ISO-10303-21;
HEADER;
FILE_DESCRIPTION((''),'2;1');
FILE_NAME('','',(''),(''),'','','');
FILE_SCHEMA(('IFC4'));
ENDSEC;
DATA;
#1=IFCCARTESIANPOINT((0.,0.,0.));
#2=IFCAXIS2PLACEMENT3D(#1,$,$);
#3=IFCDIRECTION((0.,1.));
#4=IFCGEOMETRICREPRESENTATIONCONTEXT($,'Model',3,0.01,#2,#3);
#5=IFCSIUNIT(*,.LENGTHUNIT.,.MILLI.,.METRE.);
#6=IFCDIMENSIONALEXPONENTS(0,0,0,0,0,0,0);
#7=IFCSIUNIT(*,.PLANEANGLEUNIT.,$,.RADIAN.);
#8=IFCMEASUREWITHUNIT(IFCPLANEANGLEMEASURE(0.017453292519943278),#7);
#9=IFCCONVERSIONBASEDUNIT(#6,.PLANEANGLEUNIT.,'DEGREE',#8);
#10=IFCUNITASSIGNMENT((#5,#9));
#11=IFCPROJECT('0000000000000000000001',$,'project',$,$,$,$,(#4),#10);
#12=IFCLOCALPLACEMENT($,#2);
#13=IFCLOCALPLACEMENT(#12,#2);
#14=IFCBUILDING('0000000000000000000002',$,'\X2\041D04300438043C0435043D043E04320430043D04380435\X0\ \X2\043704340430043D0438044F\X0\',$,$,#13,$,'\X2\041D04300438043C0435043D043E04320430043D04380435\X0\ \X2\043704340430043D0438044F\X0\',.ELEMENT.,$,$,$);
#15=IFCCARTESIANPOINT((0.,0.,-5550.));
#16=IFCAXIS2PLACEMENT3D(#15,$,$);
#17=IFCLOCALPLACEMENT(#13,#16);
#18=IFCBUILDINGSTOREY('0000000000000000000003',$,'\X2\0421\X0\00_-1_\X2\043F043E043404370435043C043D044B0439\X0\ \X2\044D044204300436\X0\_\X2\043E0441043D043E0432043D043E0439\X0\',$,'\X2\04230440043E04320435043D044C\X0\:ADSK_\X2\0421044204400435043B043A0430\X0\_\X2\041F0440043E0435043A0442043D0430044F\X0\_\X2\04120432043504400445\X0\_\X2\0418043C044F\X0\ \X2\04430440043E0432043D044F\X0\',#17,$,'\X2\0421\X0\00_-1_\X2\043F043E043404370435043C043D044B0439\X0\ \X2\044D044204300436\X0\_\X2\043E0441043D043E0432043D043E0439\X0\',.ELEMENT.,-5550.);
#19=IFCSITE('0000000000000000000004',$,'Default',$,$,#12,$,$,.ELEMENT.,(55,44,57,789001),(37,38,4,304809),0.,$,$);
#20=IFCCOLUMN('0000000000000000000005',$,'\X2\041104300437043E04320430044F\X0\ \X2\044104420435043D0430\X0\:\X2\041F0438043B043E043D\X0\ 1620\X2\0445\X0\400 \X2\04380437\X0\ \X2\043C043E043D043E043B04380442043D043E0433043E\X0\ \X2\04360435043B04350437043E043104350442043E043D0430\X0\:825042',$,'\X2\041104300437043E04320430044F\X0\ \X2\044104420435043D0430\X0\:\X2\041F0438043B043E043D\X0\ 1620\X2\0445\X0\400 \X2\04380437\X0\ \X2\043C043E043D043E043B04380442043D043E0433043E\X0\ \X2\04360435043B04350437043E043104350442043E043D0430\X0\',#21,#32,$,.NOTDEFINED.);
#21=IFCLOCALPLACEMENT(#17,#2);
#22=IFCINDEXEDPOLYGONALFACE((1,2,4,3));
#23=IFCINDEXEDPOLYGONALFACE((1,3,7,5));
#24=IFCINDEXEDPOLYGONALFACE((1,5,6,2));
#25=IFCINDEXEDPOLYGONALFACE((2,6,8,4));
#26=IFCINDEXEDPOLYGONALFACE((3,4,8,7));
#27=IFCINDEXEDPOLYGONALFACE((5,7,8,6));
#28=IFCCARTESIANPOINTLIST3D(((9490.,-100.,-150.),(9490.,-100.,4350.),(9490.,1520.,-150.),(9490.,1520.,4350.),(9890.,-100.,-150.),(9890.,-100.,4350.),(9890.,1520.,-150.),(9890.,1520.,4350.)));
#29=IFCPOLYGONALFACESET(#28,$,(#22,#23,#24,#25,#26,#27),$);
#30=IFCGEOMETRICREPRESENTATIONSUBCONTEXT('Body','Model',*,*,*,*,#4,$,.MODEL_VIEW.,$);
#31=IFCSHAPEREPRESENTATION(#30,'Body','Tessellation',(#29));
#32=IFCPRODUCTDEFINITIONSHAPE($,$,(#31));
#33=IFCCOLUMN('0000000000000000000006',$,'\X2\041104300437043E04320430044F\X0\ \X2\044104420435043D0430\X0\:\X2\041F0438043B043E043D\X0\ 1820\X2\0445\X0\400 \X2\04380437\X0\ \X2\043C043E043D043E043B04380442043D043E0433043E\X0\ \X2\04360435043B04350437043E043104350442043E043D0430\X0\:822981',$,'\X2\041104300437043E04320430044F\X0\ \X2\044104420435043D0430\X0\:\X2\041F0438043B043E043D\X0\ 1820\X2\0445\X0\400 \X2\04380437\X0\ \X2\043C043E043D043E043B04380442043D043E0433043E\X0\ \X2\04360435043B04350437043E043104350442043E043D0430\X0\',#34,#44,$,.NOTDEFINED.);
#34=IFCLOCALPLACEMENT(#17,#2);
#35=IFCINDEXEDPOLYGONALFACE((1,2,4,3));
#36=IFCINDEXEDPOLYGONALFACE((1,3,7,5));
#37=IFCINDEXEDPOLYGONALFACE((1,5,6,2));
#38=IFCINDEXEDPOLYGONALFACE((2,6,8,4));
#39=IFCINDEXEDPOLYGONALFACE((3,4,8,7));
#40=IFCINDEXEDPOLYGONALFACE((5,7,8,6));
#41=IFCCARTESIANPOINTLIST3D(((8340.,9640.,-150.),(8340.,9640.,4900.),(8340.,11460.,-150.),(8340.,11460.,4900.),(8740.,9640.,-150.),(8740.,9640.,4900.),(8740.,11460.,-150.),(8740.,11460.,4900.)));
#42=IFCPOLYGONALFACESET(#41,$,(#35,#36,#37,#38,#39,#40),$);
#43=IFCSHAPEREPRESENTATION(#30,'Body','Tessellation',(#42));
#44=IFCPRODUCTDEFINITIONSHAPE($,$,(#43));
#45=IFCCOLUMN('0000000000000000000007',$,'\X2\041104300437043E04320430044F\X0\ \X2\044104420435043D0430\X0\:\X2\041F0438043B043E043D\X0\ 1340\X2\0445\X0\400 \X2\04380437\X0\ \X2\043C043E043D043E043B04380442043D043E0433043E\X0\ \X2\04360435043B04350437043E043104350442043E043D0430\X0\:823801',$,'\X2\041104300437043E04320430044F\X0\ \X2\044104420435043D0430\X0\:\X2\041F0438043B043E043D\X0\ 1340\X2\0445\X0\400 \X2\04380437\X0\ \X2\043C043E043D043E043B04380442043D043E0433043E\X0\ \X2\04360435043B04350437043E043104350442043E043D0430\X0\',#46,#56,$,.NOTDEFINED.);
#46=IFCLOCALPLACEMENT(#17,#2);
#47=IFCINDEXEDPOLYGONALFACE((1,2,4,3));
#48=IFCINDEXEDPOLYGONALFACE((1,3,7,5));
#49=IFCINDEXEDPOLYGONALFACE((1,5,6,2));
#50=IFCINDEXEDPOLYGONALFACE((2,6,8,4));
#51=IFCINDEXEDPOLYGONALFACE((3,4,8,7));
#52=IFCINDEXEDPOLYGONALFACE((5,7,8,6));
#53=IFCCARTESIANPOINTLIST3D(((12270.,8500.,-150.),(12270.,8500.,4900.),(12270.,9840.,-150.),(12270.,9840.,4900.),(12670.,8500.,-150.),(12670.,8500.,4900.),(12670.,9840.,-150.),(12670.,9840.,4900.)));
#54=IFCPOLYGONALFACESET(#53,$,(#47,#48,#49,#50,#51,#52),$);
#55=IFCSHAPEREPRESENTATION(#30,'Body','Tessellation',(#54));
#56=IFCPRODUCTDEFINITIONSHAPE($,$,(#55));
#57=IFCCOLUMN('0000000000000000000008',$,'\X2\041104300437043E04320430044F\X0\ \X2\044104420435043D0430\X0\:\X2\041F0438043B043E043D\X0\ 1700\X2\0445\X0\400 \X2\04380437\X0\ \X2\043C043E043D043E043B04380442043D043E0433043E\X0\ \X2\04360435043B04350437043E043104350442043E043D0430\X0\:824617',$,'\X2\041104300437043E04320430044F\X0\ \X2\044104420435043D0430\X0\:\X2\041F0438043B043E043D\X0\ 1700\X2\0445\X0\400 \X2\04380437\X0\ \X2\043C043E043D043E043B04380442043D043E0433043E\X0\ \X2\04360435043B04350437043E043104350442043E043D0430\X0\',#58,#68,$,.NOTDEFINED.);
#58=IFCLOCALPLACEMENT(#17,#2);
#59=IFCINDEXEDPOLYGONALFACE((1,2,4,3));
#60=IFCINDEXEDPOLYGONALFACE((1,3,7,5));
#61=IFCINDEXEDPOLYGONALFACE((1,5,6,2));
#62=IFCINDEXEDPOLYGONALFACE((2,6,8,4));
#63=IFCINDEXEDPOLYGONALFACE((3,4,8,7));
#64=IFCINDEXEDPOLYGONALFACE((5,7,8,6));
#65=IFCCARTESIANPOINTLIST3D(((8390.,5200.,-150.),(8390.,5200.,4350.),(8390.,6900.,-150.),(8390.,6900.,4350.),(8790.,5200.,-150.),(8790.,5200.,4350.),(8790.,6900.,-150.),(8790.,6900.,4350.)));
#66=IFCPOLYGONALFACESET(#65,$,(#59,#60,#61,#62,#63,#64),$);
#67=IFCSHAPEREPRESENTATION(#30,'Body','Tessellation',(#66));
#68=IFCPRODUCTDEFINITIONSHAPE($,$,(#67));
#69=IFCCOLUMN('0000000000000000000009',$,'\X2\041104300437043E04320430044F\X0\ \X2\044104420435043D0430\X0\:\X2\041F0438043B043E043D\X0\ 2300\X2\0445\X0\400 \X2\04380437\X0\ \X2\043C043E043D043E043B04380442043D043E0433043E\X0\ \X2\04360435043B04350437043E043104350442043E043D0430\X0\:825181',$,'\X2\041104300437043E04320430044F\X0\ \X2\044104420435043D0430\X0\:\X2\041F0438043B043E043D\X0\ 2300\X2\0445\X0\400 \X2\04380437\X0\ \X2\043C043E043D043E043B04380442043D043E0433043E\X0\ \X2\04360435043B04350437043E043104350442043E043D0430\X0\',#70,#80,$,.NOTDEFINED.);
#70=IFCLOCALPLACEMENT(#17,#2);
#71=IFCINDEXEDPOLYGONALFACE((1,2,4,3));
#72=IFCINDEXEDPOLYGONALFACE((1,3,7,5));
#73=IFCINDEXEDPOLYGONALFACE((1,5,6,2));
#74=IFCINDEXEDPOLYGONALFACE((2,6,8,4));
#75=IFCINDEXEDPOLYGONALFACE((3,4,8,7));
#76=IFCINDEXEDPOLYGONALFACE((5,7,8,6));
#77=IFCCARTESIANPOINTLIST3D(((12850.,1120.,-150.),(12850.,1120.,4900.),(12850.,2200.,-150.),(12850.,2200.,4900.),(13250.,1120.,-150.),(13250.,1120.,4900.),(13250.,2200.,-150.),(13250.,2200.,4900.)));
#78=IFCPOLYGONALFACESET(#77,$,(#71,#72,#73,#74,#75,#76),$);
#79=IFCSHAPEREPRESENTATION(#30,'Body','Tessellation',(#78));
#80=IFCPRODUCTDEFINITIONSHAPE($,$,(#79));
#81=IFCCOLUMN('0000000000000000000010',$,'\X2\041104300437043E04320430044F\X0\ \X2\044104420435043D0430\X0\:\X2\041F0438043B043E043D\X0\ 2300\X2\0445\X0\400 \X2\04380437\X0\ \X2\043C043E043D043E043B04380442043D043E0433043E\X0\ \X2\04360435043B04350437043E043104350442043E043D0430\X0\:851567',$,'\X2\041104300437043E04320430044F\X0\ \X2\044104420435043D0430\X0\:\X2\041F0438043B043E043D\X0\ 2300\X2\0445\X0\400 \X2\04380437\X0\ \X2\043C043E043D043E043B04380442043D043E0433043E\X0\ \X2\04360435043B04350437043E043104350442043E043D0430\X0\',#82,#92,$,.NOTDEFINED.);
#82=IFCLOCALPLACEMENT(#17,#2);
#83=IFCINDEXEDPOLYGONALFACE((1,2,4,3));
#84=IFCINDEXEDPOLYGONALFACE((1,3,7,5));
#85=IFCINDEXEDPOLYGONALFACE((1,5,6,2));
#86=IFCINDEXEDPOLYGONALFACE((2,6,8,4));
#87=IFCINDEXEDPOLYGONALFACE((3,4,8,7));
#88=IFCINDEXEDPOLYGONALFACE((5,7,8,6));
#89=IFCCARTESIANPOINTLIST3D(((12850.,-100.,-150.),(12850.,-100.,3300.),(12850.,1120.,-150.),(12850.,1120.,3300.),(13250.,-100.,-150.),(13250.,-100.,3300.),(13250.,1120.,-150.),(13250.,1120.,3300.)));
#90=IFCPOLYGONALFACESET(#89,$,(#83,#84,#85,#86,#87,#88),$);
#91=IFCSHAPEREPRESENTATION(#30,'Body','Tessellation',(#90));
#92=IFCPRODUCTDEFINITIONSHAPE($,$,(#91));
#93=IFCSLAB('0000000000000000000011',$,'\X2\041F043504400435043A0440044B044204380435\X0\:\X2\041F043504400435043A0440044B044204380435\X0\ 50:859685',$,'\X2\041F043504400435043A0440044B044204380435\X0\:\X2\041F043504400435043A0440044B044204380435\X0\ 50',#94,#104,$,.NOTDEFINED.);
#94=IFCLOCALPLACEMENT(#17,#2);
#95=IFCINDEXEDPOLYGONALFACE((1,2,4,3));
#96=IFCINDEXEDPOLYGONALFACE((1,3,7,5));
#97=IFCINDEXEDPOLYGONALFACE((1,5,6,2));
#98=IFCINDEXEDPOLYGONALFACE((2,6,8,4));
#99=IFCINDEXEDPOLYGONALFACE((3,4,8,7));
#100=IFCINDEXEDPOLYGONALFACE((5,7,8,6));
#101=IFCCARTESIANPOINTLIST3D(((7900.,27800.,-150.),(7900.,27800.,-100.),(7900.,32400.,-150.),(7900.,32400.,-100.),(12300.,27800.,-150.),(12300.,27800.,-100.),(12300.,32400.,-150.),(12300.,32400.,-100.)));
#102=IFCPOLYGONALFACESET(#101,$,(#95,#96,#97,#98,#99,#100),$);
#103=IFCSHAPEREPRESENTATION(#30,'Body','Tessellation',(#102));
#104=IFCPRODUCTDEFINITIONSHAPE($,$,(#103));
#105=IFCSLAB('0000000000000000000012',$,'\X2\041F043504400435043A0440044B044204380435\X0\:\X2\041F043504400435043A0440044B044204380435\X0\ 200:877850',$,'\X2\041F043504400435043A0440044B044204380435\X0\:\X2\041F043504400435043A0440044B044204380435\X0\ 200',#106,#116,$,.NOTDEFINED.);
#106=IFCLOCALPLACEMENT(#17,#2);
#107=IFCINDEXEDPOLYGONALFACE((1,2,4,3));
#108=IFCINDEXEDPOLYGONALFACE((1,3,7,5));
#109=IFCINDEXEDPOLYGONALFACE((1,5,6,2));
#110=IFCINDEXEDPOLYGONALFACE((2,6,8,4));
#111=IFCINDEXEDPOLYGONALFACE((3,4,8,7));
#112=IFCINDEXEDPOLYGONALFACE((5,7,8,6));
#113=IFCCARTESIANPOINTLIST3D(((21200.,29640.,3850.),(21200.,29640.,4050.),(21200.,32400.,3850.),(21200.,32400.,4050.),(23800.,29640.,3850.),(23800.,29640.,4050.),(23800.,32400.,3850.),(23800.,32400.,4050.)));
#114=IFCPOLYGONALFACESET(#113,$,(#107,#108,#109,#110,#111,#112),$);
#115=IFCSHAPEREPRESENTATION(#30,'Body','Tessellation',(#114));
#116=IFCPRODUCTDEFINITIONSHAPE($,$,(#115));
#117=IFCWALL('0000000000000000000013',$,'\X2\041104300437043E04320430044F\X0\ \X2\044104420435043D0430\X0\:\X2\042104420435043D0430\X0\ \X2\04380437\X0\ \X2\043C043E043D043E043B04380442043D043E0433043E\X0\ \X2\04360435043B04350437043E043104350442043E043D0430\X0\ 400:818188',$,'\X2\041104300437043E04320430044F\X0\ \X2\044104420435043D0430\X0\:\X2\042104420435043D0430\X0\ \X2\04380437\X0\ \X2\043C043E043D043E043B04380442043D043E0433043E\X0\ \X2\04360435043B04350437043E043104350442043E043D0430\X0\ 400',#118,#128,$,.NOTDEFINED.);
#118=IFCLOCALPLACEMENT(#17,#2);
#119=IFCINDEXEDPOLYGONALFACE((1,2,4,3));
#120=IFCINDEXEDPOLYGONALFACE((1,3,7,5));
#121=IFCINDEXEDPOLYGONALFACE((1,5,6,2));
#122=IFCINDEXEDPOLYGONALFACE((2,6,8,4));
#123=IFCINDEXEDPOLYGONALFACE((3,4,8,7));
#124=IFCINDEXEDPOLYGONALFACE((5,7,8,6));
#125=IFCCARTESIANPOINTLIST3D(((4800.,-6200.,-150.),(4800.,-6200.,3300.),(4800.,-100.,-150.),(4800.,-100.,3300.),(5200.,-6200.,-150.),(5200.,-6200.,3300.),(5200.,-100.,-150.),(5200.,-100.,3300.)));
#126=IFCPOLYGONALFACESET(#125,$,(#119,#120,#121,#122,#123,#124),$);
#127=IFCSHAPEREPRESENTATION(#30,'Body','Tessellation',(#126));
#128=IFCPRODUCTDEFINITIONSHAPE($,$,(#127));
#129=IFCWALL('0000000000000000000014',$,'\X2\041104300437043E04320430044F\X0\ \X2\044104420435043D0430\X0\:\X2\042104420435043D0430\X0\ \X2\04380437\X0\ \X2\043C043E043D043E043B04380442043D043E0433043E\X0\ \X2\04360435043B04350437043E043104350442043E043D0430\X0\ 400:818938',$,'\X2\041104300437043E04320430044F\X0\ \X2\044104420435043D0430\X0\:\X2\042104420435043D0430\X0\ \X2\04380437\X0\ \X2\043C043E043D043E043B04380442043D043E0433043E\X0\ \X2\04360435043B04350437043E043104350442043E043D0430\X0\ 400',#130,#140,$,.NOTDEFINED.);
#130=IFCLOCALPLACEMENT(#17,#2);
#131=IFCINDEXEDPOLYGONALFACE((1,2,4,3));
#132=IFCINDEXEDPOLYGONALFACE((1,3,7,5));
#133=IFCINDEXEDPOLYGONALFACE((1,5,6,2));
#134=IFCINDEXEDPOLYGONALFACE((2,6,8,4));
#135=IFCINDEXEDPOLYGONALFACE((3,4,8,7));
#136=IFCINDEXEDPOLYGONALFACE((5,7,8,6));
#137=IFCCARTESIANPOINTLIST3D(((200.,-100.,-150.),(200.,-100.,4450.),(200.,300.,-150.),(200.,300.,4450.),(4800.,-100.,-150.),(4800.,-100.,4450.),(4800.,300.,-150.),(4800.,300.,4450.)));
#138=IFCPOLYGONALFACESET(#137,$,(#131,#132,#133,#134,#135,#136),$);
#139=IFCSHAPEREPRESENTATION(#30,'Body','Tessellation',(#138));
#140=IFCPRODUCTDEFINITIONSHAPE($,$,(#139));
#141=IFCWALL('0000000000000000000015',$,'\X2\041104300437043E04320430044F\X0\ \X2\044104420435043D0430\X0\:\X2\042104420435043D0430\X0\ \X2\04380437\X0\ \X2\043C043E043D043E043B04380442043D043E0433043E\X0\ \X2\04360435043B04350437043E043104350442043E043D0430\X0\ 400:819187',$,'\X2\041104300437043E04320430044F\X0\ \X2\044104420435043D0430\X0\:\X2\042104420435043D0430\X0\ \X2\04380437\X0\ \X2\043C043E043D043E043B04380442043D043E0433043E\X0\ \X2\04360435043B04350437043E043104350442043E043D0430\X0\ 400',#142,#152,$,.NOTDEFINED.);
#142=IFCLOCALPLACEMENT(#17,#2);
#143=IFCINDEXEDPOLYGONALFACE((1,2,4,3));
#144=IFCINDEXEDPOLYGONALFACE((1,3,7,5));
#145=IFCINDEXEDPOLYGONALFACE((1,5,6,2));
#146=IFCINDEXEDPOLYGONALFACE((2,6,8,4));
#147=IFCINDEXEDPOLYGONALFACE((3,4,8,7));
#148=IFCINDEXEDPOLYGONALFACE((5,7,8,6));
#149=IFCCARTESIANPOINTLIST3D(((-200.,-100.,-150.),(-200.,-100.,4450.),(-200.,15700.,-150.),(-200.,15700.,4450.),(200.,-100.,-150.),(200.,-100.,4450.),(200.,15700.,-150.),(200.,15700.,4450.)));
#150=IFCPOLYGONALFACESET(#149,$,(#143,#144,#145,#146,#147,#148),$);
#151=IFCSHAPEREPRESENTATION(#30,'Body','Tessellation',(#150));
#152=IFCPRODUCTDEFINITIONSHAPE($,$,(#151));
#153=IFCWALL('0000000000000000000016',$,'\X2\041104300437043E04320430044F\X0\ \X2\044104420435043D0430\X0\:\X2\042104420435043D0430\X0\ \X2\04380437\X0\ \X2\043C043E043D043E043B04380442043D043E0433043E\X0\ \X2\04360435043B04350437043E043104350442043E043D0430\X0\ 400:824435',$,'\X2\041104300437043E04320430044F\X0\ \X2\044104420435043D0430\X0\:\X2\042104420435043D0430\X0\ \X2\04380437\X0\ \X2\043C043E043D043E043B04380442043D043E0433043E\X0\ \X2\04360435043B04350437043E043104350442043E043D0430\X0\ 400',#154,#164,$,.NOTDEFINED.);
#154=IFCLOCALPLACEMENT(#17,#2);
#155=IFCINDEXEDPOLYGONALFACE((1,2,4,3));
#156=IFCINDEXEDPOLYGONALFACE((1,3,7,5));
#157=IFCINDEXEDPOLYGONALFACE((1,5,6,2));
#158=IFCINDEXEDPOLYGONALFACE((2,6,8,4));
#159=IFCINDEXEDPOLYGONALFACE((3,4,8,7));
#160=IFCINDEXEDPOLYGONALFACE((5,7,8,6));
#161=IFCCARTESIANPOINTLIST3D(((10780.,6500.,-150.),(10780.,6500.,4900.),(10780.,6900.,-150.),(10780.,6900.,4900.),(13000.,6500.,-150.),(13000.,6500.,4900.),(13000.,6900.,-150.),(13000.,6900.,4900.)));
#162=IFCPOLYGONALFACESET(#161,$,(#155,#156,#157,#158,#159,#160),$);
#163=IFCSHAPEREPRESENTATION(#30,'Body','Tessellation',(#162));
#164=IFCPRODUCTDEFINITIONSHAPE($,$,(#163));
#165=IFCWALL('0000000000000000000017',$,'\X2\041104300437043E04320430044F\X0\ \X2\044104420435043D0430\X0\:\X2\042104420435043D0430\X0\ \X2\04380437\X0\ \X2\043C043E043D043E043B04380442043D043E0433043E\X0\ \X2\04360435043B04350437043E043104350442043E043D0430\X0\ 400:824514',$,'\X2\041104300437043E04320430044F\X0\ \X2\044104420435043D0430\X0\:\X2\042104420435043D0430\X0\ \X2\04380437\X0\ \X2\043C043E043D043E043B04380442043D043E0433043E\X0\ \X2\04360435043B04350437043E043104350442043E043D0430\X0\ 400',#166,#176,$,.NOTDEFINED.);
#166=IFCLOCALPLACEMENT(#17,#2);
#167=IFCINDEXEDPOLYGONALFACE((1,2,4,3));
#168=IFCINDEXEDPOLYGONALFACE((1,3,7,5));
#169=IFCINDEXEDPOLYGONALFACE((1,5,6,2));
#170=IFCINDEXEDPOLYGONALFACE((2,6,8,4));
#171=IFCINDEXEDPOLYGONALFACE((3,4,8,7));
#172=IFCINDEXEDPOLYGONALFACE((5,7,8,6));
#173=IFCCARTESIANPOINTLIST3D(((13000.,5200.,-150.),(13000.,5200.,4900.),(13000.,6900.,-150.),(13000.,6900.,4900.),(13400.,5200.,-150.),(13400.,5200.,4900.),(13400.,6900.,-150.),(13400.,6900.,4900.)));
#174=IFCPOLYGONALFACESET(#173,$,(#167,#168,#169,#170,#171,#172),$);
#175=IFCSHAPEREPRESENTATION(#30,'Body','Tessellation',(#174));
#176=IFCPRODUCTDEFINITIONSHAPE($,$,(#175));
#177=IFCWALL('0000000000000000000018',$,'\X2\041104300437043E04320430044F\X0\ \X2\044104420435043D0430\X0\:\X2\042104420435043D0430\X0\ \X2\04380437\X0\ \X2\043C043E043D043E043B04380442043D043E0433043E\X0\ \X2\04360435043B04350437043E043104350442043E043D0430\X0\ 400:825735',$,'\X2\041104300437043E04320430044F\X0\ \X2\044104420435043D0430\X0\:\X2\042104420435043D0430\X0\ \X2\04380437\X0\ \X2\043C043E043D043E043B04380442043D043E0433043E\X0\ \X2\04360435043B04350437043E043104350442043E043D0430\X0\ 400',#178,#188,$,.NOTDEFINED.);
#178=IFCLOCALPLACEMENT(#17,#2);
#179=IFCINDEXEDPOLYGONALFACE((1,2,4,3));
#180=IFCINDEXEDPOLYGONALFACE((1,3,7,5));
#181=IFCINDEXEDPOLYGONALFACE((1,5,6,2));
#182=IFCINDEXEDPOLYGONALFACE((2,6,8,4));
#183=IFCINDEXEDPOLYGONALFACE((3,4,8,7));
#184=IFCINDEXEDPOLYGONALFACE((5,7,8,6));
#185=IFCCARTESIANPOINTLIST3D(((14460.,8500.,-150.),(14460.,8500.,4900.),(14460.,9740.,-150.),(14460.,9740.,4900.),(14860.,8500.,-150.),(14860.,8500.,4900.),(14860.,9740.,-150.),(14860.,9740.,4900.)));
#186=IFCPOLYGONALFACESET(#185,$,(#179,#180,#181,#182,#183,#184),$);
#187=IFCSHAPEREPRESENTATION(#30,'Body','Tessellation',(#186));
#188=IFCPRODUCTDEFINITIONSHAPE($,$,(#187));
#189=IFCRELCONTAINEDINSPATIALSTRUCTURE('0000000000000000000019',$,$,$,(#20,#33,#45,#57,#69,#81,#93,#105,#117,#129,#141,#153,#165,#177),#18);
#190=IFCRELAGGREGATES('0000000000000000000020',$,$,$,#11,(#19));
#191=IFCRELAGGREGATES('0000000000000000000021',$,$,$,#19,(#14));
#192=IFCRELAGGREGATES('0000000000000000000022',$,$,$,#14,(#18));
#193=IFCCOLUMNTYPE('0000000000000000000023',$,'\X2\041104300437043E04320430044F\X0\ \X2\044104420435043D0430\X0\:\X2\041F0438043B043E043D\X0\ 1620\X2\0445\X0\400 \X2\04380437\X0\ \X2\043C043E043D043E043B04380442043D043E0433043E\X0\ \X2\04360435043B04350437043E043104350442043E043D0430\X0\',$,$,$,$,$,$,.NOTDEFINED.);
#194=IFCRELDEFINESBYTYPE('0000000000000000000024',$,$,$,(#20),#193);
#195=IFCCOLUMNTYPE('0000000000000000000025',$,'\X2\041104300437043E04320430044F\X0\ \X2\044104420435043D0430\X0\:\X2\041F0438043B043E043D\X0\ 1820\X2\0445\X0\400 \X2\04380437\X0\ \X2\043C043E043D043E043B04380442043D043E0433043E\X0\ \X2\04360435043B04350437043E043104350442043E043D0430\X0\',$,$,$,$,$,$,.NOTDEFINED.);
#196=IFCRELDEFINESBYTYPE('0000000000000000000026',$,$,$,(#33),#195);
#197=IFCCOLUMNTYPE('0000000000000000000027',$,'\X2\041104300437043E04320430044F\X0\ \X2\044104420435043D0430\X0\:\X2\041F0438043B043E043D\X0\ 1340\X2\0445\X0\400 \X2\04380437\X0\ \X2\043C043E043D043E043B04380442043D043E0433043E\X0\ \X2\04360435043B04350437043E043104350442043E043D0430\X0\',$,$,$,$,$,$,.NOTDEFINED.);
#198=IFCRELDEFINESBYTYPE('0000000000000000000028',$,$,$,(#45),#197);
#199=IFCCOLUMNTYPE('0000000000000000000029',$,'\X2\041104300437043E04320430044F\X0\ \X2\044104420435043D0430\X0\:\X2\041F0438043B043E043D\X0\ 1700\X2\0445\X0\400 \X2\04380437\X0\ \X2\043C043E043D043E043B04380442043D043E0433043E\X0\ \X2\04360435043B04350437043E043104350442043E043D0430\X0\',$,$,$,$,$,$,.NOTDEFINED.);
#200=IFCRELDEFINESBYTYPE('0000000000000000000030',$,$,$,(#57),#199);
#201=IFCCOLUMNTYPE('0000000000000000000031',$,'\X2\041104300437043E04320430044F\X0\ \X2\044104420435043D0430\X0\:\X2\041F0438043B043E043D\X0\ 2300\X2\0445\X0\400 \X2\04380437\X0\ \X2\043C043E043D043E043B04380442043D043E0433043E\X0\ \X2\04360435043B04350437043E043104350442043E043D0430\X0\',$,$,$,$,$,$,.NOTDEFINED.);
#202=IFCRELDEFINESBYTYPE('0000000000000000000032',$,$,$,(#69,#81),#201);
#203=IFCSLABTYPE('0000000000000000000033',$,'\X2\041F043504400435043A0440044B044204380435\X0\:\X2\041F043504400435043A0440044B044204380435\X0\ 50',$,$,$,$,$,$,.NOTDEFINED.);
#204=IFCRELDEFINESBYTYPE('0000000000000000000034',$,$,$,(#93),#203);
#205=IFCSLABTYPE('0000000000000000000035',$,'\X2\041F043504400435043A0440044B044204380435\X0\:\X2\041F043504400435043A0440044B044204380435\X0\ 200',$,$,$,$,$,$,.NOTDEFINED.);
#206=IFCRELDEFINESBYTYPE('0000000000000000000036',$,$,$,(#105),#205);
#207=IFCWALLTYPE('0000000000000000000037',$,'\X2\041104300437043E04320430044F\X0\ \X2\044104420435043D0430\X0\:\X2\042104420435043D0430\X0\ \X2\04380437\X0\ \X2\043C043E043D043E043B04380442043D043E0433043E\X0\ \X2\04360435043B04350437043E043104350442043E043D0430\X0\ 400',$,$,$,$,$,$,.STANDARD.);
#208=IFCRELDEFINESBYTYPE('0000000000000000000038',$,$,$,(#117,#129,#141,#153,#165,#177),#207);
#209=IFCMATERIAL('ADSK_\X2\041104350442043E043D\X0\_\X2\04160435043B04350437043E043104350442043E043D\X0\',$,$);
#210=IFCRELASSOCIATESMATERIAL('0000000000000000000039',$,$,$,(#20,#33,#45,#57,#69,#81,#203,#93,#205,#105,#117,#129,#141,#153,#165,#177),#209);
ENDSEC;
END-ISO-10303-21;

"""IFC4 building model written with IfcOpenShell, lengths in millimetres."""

from ifc_helpers import new_model, entity, si_unit, converted_unit, direction, frame, origin, place, context, subcontext, project, spatial, indexed_curve, outline, extrude, material, type_object, element, save


model = new_model("IFC4")

# Units and contexts
model_context = context("Model", 3, precision=0.01, world=origin(), true_north=direction((0.0, 1.0)))
body_context = subcontext(model_context, "Body", "Model", "MODEL_VIEW")
ifc_project = project(units=[si_unit("LENGTHUNIT", "METRE", prefix="MILLI"), converted_unit("PLANEANGLEUNIT", "DEGREE", entity("IfcPlaneAngleMeasure", 0.017453292519943278), si_unit("PLANEANGLEUNIT", "RADIAN"), dimensions=[0, 0, 0, 0, 0, 0, 0])], contexts=[model_context])

# Site, building, storey
site_placement = place(None, origin())
site = spatial("IfcSite", under=ifc_project, at=site_placement, Name="Default", CompositionType="ELEMENT", RefLatitude=(55, 44, 57, 789001), RefLongitude=(37, 38, 4, 304809), RefElevation=0.0)
building_placement = place(site_placement, origin())
building = spatial("IfcBuilding", under=site, at=building_placement, Name="Наименование здания", LongName="Наименование здания", CompositionType="ELEMENT")
storey_placement = place(building_placement, frame((0.0, 0.0, -5550.0)))
storey = spatial("IfcBuildingStorey", under=building, at=storey_placement, Name="С00_-1_подземный этаж_основной", ObjectType="Уровень:ADSK_Стрелка_Проектная_Вверх_Имя уровня", LongName="С00_-1_подземный этаж_основной", CompositionType="ELEMENT", Elevation=-5550.0)

# Columns
ifc_material_1 = material(Name="ADSK_Бетон_Железобетон")
column_type_1 = type_object("IfcColumnType", Name="Базовая стена:Пилон 1620х400 из монолитного железобетона", PredefinedType="NOTDEFINED")
column_1_placement = place(storey_placement, frame((9690.0, 1520.0, -150.0), z_axis=(0.0, 0.0, 1.0), x_axis=(0.0, -1.0, 0.0)))
element("IfcColumn", 1, at=column_1_placement, inside=storey, type_object=column_type_1, material=ifc_material_1, Name="Базовая стена:Пилон 1620х400 из монолитного железобетона:825042", ObjectType="Базовая стена:Пилон 1620х400 из монолитного железобетона", PredefinedType="NOTDEFINED", context=body_context, shape_type="SweptSolid", body=[
    extrude(outline(indexed_curve([(1620.0, 200.0), (0.0, 200.0), (0.0, -200.0), (1620.0, -200.0), (1620.0, 200.0)], self_intersect=False)), origin(), (0.0, 0.0, 1.0), 4500.0),
])
column_type_2 = type_object("IfcColumnType", Name="Базовая стена:Пилон 1820х400 из монолитного железобетона", PredefinedType="NOTDEFINED")
column_2_placement = place(storey_placement, frame((8540.0, 9640.0, -150.0), z_axis=(0.0, 0.0, 1.0), x_axis=(0.0, 1.0, 0.0)))
element("IfcColumn", 2, at=column_2_placement, inside=storey, type_object=column_type_2, material=ifc_material_1, Name="Базовая стена:Пилон 1820х400 из монолитного железобетона:822981", ObjectType="Базовая стена:Пилон 1820х400 из монолитного железобетона", PredefinedType="NOTDEFINED", context=body_context, shape_type="SweptSolid", body=[
    extrude(outline(indexed_curve([(1820.0, 200.0), (0.0, 200.0), (0.0, -200.0), (1820.0, -200.0), (1820.0, 200.0)], self_intersect=False)), origin(), (0.0, 0.0, 1.0), 5050.0),
])
column_type_3 = type_object("IfcColumnType", Name="Базовая стена:Пилон 1340х400 из монолитного железобетона", PredefinedType="NOTDEFINED")
column_3_placement = place(storey_placement, frame((12470.0, 8500.0, -150.0), z_axis=(0.0, 0.0, 1.0), x_axis=(0.0, 1.0, 0.0)))
element("IfcColumn", 3, at=column_3_placement, inside=storey, type_object=column_type_3, material=ifc_material_1, Name="Базовая стена:Пилон 1340х400 из монолитного железобетона:823801", ObjectType="Базовая стена:Пилон 1340х400 из монолитного железобетона", PredefinedType="NOTDEFINED", context=body_context, shape_type="SweptSolid", body=[
    extrude(outline(indexed_curve([(1340.0, 200.0), (0.0, 200.0), (0.0, -200.0), (1340.0, -200.0), (1340.0, 200.0)], self_intersect=False)), origin(), (0.0, 0.0, 1.0), 5050.0),
])
column_type_4 = type_object("IfcColumnType", Name="Базовая стена:Пилон 1700х400 из монолитного железобетона", PredefinedType="NOTDEFINED")
column_4_placement = place(storey_placement, frame((8590.0, 5200.0, -150.0), z_axis=(0.0, 0.0, 1.0), x_axis=(0.0, 1.0, 0.0)))
element("IfcColumn", 4, at=column_4_placement, inside=storey, type_object=column_type_4, material=ifc_material_1, Name="Базовая стена:Пилон 1700х400 из монолитного железобетона:824617", ObjectType="Базовая стена:Пилон 1700х400 из монолитного железобетона", PredefinedType="NOTDEFINED", context=body_context, shape_type="SweptSolid", body=[
    extrude(outline(indexed_curve([(1700.0, 200.0), (0.0, 200.0), (0.0, -200.0), (1700.0, -200.0), (1700.0, 200.0)], self_intersect=False)), origin(), (0.0, 0.0, 1.0), 4500.0),
])
column_type_5 = type_object("IfcColumnType", Name="Базовая стена:Пилон 2300х400 из монолитного железобетона", PredefinedType="NOTDEFINED")
column_5_placement = place(storey_placement, frame((13050.0, 2200.0, -150.0), z_axis=(0.0, 0.0, 1.0), x_axis=(0.0, -1.0, 0.0)))
element("IfcColumn", 5, at=column_5_placement, inside=storey, type_object=column_type_5, material=ifc_material_1, Name="Базовая стена:Пилон 2300х400 из монолитного железобетона:825181", ObjectType="Базовая стена:Пилон 2300х400 из монолитного железобетона", PredefinedType="NOTDEFINED", context=body_context, shape_type="SweptSolid", body=[
    extrude(outline(indexed_curve([(1080.0, 200.0), (0.0, 200.0), (0.0, -200.0), (1080.0, -200.0), (1080.0, 200.0)], self_intersect=False)), origin(), (0.0, 0.0, 1.0), 5050.0),
])
column_6_placement = place(storey_placement, frame((13050.0, 1120.0, -150.0), z_axis=(0.0, 0.0, 1.0), x_axis=(0.0, -1.0, 0.0)))
element("IfcColumn", 6, at=column_6_placement, inside=storey, type_object=column_type_5, material=ifc_material_1, Name="Базовая стена:Пилон 2300х400 из монолитного железобетона:851567", ObjectType="Базовая стена:Пилон 2300х400 из монолитного железобетона", PredefinedType="NOTDEFINED", context=body_context, shape_type="SweptSolid", body=[
    extrude(outline(indexed_curve([(1220.0, 200.0), (0.0, 200.0), (0.0, -200.0), (1220.0, -200.0), (1220.0, 200.0)], self_intersect=False)), origin(), (0.0, 0.0, 1.0), 3450.0),
])

# Slabs
slab_type_1 = type_object("IfcSlabType", Name="Перекрытие:Перекрытие 50", PredefinedType="NOTDEFINED", material=ifc_material_1)
slab_1_placement = place(storey_placement, origin())
element("IfcSlab", 7, at=slab_1_placement, inside=storey, type_object=slab_type_1, material=ifc_material_1, Name="Перекрытие:Перекрытие 50:859685", ObjectType="Перекрытие:Перекрытие 50", PredefinedType="NOTDEFINED", context=body_context, shape_type="SweptSolid", body=[
    extrude(outline(indexed_curve([(-2300.0, -2200.0), (2300.0, -2200.0), (2300.0, 2200.0), (-2300.0, 2200.0), (-2300.0, -2200.0)], self_intersect=False)), frame((10100.0, 30100.0, -100.0), z_axis=(0.0, 0.0, -1.0), x_axis=(0.0, 1.0, 0.0)), (0.0, 0.0, 1.0), 50.0),
])
slab_type_2 = type_object("IfcSlabType", Name="Перекрытие:Перекрытие 200", PredefinedType="NOTDEFINED", material=ifc_material_1)
slab_2_placement = place(storey_placement, origin())
element("IfcSlab", 8, at=slab_2_placement, inside=storey, type_object=slab_type_2, material=ifc_material_1, Name="Перекрытие:Перекрытие 200:877850", ObjectType="Перекрытие:Перекрытие 200", PredefinedType="NOTDEFINED", context=body_context, shape_type="SweptSolid", body=[
    extrude(outline(indexed_curve([(-1380.0, -1300.0), (1380.0, -1300.0), (1380.0, 1300.0), (-1380.0, 1300.0), (-1380.0, -1300.0)], self_intersect=False)), frame((22500.0, 31020.0, 4050.0), z_axis=(0.0, 0.0, -1.0), x_axis=(0.0, 1.0, 0.0)), (0.0, 0.0, 1.0), 200.0),
])

# Walls
wall_type_1 = type_object("IfcWallType", Name="Базовая стена:Стена из монолитного железобетона 400", PredefinedType="STANDARD")
wall_1_placement = place(storey_placement, frame((5000.0, -6200.0, -150.0), z_axis=(0.0, 0.0, 1.0), x_axis=(0.0, 1.0, 0.0)))
element("IfcWall", 9, at=wall_1_placement, inside=storey, type_object=wall_type_1, material=ifc_material_1, Name="Базовая стена:Стена из монолитного железобетона 400:818188", ObjectType="Базовая стена:Стена из монолитного железобетона 400", PredefinedType="NOTDEFINED", context=body_context, shape_type="SweptSolid", body=[
    extrude(outline(indexed_curve([(6100.0, 200.0), (0.0, 200.0), (0.0, -200.0), (6100.0, -200.0), (6100.0, 200.0)], self_intersect=False)), origin(), (0.0, 0.0, 1.0), 3450.0),
])
wall_2_placement = place(storey_placement, frame((4800.0, 100.0, -150.0), z_axis=(0.0, 0.0, 1.0), x_axis=(-1.0, 0.0, 0.0)))
element("IfcWall", 10, at=wall_2_placement, inside=storey, type_object=wall_type_1, material=ifc_material_1, Name="Базовая стена:Стена из монолитного железобетона 400:818938", ObjectType="Базовая стена:Стена из монолитного железобетона 400", PredefinedType="NOTDEFINED", context=body_context, shape_type="SweptSolid", body=[
    extrude(outline(indexed_curve([(4600.0, 200.0), (0.0, 200.0), (0.0, -200.0), (4600.0, -200.0), (4600.0, 200.0)], self_intersect=False)), origin(), (0.0, 0.0, 1.0), 4600.0),
])
wall_3_placement = place(storey_placement, frame((0.0, -100.0, -150.0), z_axis=(0.0, 0.0, 1.0), x_axis=(0.0, 1.0, 0.0)))
element("IfcWall", 11, at=wall_3_placement, inside=storey, type_object=wall_type_1, material=ifc_material_1, Name="Базовая стена:Стена из монолитного железобетона 400:819187", ObjectType="Базовая стена:Стена из монолитного железобетона 400", PredefinedType="NOTDEFINED", context=body_context, shape_type="SweptSolid", body=[
    extrude(outline(indexed_curve([(15800.0, 200.0), (0.0, 200.0), (0.0, -200.0), (15800.0, -200.0), (15800.0, 200.0)], self_intersect=False)), origin(), (0.0, 0.0, 1.0), 4600.0),
])
wall_4_placement = place(storey_placement, frame((10780.0, 6700.0, -150.0)))
element("IfcWall", 12, at=wall_4_placement, inside=storey, type_object=wall_type_1, material=ifc_material_1, Name="Базовая стена:Стена из монолитного железобетона 400:824435", ObjectType="Базовая стена:Стена из монолитного железобетона 400", PredefinedType="NOTDEFINED", context=body_context, shape_type="SweptSolid", body=[
    extrude(outline(indexed_curve([(2220.0, 200.0), (0.0, 200.0), (0.0, -200.0), (2220.0, -200.0), (2220.0, 200.0)], self_intersect=False)), origin(), (0.0, 0.0, 1.0), 5050.0),
])
wall_5_placement = place(storey_placement, frame((13200.0, 6900.0, -150.0), z_axis=(0.0, 0.0, 1.0), x_axis=(0.0, -1.0, 0.0)))
element("IfcWall", 13, at=wall_5_placement, inside=storey, type_object=wall_type_1, material=ifc_material_1, Name="Базовая стена:Стена из монолитного железобетона 400:824514", ObjectType="Базовая стена:Стена из монолитного железобетона 400", PredefinedType="NOTDEFINED", context=body_context, shape_type="SweptSolid", body=[
    extrude(outline(indexed_curve([(1700.0, 200.0), (0.0, 200.0), (0.0, -200.0), (1700.0, -200.0), (1700.0, 200.0)], self_intersect=False)), origin(), (0.0, 0.0, 1.0), 5050.0),
])
wall_6_placement = place(storey_placement, frame((14660.0, 9740.0, -150.0), z_axis=(0.0, 0.0, 1.0), x_axis=(0.0, -1.0, 0.0)))
element("IfcWall", 14, at=wall_6_placement, inside=storey, type_object=wall_type_1, material=ifc_material_1, Name="Базовая стена:Стена из монолитного железобетона 400:825735", ObjectType="Базовая стена:Стена из монолитного железобетона 400", PredefinedType="NOTDEFINED", context=body_context, shape_type="SweptSolid", body=[
    extrude(outline(indexed_curve([(1240.0, 200.0), (0.0, 200.0), (0.0, -200.0), (1240.0, -200.0), (1240.0, 200.0)], self_intersect=False)), origin(), (0.0, 0.0, 1.0), 5050.0),
])

save(model, "model.ifc")
